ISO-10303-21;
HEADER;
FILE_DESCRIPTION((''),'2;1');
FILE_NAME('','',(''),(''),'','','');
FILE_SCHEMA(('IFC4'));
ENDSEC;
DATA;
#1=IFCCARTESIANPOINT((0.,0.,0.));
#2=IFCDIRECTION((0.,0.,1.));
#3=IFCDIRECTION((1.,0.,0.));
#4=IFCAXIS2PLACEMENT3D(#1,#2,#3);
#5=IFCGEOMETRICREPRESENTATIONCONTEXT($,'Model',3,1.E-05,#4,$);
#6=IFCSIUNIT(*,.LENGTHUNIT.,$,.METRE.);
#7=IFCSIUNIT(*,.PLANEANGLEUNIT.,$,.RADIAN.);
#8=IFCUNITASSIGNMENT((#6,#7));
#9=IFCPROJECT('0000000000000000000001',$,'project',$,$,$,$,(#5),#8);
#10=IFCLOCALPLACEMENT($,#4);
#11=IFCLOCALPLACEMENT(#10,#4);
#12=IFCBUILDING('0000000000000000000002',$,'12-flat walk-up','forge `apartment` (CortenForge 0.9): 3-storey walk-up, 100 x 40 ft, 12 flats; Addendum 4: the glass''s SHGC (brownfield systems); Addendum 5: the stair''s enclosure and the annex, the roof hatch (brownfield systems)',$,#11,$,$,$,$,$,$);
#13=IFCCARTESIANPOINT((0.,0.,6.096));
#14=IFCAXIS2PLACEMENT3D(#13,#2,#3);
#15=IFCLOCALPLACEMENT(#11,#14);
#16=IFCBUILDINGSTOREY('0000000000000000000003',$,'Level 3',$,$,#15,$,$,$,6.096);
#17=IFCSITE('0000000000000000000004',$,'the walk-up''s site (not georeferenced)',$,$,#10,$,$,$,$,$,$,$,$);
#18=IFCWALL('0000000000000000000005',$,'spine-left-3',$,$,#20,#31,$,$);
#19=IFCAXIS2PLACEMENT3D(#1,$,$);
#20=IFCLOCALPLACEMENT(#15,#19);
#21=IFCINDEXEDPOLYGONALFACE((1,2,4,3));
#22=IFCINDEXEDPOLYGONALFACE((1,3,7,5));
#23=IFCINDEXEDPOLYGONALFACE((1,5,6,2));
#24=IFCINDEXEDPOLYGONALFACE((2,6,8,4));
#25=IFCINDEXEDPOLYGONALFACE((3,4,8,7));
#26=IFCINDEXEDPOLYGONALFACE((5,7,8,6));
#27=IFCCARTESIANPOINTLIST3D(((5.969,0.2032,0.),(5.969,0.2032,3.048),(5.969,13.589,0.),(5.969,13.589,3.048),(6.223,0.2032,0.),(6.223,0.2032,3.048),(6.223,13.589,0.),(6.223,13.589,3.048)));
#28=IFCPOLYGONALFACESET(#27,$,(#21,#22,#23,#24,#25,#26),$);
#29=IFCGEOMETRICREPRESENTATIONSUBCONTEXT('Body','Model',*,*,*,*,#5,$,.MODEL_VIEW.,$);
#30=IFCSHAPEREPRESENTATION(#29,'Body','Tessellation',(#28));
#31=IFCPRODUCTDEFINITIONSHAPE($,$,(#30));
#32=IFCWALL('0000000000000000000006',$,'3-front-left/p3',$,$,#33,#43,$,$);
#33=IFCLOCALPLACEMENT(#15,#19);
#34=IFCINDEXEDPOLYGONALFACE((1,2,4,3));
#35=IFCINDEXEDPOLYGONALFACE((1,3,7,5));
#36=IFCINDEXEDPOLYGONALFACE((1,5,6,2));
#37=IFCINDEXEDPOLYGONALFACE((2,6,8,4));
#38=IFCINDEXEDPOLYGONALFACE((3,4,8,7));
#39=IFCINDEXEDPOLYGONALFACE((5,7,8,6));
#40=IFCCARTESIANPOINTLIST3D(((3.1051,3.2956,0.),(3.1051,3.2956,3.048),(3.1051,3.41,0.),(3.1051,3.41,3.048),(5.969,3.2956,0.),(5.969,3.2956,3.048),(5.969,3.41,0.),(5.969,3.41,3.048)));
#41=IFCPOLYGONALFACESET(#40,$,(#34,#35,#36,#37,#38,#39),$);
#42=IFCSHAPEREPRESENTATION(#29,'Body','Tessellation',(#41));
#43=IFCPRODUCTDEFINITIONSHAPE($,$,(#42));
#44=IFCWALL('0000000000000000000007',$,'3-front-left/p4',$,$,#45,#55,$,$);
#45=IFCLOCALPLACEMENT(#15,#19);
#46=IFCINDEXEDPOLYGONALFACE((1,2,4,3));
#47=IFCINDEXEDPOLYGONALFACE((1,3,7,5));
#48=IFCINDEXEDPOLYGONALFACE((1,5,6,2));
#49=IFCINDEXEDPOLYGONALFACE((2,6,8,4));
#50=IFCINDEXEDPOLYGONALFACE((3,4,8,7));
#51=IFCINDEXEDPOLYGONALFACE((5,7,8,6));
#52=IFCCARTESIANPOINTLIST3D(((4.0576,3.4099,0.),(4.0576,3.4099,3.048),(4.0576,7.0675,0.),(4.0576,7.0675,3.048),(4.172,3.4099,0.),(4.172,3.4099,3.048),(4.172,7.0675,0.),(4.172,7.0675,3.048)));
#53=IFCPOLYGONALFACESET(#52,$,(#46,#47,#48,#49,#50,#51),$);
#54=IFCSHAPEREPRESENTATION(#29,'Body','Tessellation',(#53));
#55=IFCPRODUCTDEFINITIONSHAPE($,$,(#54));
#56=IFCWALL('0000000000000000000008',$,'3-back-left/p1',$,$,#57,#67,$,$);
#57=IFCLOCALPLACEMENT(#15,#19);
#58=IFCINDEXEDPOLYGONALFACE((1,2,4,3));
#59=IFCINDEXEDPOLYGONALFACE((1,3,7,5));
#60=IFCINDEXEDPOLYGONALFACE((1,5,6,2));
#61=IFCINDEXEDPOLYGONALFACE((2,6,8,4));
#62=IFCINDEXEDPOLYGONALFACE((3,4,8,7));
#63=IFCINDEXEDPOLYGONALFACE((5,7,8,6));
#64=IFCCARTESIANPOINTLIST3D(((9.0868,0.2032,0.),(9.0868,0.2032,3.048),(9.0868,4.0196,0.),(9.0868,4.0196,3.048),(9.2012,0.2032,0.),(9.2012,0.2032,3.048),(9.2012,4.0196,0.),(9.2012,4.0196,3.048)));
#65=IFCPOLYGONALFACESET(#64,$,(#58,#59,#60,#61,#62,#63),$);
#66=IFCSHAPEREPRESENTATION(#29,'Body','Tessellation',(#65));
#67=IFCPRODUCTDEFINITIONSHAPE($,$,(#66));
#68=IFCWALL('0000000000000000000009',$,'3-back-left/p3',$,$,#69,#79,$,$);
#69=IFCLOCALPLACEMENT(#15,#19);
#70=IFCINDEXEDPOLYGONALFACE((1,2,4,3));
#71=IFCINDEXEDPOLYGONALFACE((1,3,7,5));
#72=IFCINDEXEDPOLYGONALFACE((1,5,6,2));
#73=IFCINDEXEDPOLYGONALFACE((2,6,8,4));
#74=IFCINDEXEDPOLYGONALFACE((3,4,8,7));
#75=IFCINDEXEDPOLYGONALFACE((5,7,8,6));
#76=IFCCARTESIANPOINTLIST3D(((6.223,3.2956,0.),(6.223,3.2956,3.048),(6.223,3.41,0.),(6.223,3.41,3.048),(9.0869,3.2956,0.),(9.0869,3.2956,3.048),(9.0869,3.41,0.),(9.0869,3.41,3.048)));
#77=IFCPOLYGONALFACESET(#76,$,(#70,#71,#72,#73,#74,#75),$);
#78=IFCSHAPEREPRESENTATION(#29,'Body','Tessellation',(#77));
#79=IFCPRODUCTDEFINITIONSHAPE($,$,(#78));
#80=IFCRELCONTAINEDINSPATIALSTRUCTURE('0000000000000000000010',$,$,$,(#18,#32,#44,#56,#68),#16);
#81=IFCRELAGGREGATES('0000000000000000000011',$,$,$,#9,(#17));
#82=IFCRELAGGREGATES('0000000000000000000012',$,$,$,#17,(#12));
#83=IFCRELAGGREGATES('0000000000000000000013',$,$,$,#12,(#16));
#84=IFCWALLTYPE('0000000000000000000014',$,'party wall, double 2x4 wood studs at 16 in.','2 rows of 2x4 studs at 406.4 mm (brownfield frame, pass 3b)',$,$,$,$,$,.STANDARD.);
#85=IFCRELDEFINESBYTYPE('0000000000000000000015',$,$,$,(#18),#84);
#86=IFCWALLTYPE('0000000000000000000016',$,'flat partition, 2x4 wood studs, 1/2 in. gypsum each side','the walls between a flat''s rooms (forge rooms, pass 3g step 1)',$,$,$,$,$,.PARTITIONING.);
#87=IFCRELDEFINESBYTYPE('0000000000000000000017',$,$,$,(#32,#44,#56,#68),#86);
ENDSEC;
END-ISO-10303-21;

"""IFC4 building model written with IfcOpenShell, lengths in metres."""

from ifc_helpers import new_model, si_unit, frame, frame_2d, origin, origin_with_axes, place, context, subcontext, project, spatial, rectangle, extrude, type_object, element, save


model = new_model("IFC4")

# Units and contexts
model_context = context("Model", 3, precision=1e-05, world=origin_with_axes())
body_context = subcontext(model_context, "Body", "Model", "MODEL_VIEW")
ifc_project = project(units=[si_unit("LENGTHUNIT", "METRE"), si_unit("PLANEANGLEUNIT", "RADIAN")], contexts=[model_context])

# Site, building, storey
site_placement = place(None, origin_with_axes())
site = spatial("IfcSite", under=ifc_project, at=site_placement, Name="the walk-up's site (not georeferenced)")
building_placement = place(site_placement, origin_with_axes())
building = spatial("IfcBuilding", under=site, at=building_placement, Name="12-flat walk-up", Description="forge `apartment` (CortenForge 0.9): 3-storey walk-up, 100 x 40 ft, 12 flats; Addendum 4: the glass's SHGC (brownfield systems); Addendum 5: the stair's enclosure and the annex, the roof hatch (brownfield systems)")
storey_placement = place(building_placement, frame((0.0, 0.0, 6.096), z_axis=(0.0, 0.0, 1.0), x_axis=(1.0, 0.0, 0.0)))
storey = spatial("IfcBuildingStorey", under=building, at=storey_placement, Name="Level 3", Elevation=6.096)

# Walls
wall_type_1 = type_object("IfcWallType", Name="party wall, double 2x4 wood studs at 16 in.", Description="2 rows of 2x4 studs at 406.4 mm (brownfield frame, pass 3b)", PredefinedType="STANDARD")
wall_1_placement = place(storey_placement, frame((5.969, 0.2032, 0.0), z_axis=(0.0, 0.0, 1.0), x_axis=(1.0, 0.0, 0.0)))
element("IfcWall", 1, at=wall_1_placement, inside=storey, type_object=wall_type_1, Name="spine-left-3", context=body_context, shape_type="SweptSolid", body=[
    extrude(rectangle(XDim=0.254, YDim=13.3858, at=frame_2d((0.127, 6.6929))), origin(), (0.0, 0.0, 1.0), 3.048),
])
wall_type_2 = type_object("IfcWallType", Name="flat partition, 2x4 wood studs, 1/2 in. gypsum each side", Description="the walls between a flat's rooms (forge rooms, pass 3g step 1)", PredefinedType="PARTITIONING")
wall_2_placement = place(storey_placement, frame((3.1051, 3.2957, 0.0), z_axis=(0.0, 0.0, 1.0), x_axis=(1.0, 0.0, 0.0)))
element("IfcWall", 2, at=wall_2_placement, inside=storey, type_object=wall_type_2, Name="3-front-left/p3", context=body_context, shape_type="SweptSolid", body=[
    extrude(rectangle(XDim=2.8639, YDim=0.1143, at=frame_2d((1.4319, 0.0571))), origin(), (0.0, 0.0, 1.0), 3.048),
])
wall_3_placement = place(storey_placement, frame((4.0576, 3.4099, 0.0), z_axis=(0.0, 0.0, 1.0), x_axis=(1.0, 0.0, 0.0)))
element("IfcWall", 3, at=wall_3_placement, inside=storey, type_object=wall_type_2, Name="3-front-left/p4", context=body_context, shape_type="SweptSolid", body=[
    extrude(rectangle(XDim=0.1143, YDim=3.6576, at=frame_2d((0.0572, 1.8288))), origin(), (0.0, 0.0, 1.0), 3.048),
])
wall_4_placement = place(storey_placement, frame((9.0869, 0.2032, 0.0), z_axis=(0.0, 0.0, 1.0), x_axis=(1.0, 0.0, 0.0)))
element("IfcWall", 4, at=wall_4_placement, inside=storey, type_object=wall_type_2, Name="3-back-left/p1", context=body_context, shape_type="SweptSolid", body=[
    extrude(rectangle(XDim=0.1143, YDim=3.8163, at=frame_2d((0.0572, 1.9082))), origin(), (0.0, 0.0, 1.0), 3.048),
])
wall_5_placement = place(storey_placement, frame((6.223, 3.2957, 0.0), z_axis=(0.0, 0.0, 1.0), x_axis=(1.0, 0.0, 0.0)))
element("IfcWall", 5, at=wall_5_placement, inside=storey, type_object=wall_type_2, Name="3-back-left/p3", context=body_context, shape_type="SweptSolid", body=[
    extrude(rectangle(XDim=2.8639, YDim=0.1143, at=frame_2d((1.4319, 0.0571))), origin(), (0.0, 0.0, 1.0), 3.048),
])

save(model, "model.ifc")
